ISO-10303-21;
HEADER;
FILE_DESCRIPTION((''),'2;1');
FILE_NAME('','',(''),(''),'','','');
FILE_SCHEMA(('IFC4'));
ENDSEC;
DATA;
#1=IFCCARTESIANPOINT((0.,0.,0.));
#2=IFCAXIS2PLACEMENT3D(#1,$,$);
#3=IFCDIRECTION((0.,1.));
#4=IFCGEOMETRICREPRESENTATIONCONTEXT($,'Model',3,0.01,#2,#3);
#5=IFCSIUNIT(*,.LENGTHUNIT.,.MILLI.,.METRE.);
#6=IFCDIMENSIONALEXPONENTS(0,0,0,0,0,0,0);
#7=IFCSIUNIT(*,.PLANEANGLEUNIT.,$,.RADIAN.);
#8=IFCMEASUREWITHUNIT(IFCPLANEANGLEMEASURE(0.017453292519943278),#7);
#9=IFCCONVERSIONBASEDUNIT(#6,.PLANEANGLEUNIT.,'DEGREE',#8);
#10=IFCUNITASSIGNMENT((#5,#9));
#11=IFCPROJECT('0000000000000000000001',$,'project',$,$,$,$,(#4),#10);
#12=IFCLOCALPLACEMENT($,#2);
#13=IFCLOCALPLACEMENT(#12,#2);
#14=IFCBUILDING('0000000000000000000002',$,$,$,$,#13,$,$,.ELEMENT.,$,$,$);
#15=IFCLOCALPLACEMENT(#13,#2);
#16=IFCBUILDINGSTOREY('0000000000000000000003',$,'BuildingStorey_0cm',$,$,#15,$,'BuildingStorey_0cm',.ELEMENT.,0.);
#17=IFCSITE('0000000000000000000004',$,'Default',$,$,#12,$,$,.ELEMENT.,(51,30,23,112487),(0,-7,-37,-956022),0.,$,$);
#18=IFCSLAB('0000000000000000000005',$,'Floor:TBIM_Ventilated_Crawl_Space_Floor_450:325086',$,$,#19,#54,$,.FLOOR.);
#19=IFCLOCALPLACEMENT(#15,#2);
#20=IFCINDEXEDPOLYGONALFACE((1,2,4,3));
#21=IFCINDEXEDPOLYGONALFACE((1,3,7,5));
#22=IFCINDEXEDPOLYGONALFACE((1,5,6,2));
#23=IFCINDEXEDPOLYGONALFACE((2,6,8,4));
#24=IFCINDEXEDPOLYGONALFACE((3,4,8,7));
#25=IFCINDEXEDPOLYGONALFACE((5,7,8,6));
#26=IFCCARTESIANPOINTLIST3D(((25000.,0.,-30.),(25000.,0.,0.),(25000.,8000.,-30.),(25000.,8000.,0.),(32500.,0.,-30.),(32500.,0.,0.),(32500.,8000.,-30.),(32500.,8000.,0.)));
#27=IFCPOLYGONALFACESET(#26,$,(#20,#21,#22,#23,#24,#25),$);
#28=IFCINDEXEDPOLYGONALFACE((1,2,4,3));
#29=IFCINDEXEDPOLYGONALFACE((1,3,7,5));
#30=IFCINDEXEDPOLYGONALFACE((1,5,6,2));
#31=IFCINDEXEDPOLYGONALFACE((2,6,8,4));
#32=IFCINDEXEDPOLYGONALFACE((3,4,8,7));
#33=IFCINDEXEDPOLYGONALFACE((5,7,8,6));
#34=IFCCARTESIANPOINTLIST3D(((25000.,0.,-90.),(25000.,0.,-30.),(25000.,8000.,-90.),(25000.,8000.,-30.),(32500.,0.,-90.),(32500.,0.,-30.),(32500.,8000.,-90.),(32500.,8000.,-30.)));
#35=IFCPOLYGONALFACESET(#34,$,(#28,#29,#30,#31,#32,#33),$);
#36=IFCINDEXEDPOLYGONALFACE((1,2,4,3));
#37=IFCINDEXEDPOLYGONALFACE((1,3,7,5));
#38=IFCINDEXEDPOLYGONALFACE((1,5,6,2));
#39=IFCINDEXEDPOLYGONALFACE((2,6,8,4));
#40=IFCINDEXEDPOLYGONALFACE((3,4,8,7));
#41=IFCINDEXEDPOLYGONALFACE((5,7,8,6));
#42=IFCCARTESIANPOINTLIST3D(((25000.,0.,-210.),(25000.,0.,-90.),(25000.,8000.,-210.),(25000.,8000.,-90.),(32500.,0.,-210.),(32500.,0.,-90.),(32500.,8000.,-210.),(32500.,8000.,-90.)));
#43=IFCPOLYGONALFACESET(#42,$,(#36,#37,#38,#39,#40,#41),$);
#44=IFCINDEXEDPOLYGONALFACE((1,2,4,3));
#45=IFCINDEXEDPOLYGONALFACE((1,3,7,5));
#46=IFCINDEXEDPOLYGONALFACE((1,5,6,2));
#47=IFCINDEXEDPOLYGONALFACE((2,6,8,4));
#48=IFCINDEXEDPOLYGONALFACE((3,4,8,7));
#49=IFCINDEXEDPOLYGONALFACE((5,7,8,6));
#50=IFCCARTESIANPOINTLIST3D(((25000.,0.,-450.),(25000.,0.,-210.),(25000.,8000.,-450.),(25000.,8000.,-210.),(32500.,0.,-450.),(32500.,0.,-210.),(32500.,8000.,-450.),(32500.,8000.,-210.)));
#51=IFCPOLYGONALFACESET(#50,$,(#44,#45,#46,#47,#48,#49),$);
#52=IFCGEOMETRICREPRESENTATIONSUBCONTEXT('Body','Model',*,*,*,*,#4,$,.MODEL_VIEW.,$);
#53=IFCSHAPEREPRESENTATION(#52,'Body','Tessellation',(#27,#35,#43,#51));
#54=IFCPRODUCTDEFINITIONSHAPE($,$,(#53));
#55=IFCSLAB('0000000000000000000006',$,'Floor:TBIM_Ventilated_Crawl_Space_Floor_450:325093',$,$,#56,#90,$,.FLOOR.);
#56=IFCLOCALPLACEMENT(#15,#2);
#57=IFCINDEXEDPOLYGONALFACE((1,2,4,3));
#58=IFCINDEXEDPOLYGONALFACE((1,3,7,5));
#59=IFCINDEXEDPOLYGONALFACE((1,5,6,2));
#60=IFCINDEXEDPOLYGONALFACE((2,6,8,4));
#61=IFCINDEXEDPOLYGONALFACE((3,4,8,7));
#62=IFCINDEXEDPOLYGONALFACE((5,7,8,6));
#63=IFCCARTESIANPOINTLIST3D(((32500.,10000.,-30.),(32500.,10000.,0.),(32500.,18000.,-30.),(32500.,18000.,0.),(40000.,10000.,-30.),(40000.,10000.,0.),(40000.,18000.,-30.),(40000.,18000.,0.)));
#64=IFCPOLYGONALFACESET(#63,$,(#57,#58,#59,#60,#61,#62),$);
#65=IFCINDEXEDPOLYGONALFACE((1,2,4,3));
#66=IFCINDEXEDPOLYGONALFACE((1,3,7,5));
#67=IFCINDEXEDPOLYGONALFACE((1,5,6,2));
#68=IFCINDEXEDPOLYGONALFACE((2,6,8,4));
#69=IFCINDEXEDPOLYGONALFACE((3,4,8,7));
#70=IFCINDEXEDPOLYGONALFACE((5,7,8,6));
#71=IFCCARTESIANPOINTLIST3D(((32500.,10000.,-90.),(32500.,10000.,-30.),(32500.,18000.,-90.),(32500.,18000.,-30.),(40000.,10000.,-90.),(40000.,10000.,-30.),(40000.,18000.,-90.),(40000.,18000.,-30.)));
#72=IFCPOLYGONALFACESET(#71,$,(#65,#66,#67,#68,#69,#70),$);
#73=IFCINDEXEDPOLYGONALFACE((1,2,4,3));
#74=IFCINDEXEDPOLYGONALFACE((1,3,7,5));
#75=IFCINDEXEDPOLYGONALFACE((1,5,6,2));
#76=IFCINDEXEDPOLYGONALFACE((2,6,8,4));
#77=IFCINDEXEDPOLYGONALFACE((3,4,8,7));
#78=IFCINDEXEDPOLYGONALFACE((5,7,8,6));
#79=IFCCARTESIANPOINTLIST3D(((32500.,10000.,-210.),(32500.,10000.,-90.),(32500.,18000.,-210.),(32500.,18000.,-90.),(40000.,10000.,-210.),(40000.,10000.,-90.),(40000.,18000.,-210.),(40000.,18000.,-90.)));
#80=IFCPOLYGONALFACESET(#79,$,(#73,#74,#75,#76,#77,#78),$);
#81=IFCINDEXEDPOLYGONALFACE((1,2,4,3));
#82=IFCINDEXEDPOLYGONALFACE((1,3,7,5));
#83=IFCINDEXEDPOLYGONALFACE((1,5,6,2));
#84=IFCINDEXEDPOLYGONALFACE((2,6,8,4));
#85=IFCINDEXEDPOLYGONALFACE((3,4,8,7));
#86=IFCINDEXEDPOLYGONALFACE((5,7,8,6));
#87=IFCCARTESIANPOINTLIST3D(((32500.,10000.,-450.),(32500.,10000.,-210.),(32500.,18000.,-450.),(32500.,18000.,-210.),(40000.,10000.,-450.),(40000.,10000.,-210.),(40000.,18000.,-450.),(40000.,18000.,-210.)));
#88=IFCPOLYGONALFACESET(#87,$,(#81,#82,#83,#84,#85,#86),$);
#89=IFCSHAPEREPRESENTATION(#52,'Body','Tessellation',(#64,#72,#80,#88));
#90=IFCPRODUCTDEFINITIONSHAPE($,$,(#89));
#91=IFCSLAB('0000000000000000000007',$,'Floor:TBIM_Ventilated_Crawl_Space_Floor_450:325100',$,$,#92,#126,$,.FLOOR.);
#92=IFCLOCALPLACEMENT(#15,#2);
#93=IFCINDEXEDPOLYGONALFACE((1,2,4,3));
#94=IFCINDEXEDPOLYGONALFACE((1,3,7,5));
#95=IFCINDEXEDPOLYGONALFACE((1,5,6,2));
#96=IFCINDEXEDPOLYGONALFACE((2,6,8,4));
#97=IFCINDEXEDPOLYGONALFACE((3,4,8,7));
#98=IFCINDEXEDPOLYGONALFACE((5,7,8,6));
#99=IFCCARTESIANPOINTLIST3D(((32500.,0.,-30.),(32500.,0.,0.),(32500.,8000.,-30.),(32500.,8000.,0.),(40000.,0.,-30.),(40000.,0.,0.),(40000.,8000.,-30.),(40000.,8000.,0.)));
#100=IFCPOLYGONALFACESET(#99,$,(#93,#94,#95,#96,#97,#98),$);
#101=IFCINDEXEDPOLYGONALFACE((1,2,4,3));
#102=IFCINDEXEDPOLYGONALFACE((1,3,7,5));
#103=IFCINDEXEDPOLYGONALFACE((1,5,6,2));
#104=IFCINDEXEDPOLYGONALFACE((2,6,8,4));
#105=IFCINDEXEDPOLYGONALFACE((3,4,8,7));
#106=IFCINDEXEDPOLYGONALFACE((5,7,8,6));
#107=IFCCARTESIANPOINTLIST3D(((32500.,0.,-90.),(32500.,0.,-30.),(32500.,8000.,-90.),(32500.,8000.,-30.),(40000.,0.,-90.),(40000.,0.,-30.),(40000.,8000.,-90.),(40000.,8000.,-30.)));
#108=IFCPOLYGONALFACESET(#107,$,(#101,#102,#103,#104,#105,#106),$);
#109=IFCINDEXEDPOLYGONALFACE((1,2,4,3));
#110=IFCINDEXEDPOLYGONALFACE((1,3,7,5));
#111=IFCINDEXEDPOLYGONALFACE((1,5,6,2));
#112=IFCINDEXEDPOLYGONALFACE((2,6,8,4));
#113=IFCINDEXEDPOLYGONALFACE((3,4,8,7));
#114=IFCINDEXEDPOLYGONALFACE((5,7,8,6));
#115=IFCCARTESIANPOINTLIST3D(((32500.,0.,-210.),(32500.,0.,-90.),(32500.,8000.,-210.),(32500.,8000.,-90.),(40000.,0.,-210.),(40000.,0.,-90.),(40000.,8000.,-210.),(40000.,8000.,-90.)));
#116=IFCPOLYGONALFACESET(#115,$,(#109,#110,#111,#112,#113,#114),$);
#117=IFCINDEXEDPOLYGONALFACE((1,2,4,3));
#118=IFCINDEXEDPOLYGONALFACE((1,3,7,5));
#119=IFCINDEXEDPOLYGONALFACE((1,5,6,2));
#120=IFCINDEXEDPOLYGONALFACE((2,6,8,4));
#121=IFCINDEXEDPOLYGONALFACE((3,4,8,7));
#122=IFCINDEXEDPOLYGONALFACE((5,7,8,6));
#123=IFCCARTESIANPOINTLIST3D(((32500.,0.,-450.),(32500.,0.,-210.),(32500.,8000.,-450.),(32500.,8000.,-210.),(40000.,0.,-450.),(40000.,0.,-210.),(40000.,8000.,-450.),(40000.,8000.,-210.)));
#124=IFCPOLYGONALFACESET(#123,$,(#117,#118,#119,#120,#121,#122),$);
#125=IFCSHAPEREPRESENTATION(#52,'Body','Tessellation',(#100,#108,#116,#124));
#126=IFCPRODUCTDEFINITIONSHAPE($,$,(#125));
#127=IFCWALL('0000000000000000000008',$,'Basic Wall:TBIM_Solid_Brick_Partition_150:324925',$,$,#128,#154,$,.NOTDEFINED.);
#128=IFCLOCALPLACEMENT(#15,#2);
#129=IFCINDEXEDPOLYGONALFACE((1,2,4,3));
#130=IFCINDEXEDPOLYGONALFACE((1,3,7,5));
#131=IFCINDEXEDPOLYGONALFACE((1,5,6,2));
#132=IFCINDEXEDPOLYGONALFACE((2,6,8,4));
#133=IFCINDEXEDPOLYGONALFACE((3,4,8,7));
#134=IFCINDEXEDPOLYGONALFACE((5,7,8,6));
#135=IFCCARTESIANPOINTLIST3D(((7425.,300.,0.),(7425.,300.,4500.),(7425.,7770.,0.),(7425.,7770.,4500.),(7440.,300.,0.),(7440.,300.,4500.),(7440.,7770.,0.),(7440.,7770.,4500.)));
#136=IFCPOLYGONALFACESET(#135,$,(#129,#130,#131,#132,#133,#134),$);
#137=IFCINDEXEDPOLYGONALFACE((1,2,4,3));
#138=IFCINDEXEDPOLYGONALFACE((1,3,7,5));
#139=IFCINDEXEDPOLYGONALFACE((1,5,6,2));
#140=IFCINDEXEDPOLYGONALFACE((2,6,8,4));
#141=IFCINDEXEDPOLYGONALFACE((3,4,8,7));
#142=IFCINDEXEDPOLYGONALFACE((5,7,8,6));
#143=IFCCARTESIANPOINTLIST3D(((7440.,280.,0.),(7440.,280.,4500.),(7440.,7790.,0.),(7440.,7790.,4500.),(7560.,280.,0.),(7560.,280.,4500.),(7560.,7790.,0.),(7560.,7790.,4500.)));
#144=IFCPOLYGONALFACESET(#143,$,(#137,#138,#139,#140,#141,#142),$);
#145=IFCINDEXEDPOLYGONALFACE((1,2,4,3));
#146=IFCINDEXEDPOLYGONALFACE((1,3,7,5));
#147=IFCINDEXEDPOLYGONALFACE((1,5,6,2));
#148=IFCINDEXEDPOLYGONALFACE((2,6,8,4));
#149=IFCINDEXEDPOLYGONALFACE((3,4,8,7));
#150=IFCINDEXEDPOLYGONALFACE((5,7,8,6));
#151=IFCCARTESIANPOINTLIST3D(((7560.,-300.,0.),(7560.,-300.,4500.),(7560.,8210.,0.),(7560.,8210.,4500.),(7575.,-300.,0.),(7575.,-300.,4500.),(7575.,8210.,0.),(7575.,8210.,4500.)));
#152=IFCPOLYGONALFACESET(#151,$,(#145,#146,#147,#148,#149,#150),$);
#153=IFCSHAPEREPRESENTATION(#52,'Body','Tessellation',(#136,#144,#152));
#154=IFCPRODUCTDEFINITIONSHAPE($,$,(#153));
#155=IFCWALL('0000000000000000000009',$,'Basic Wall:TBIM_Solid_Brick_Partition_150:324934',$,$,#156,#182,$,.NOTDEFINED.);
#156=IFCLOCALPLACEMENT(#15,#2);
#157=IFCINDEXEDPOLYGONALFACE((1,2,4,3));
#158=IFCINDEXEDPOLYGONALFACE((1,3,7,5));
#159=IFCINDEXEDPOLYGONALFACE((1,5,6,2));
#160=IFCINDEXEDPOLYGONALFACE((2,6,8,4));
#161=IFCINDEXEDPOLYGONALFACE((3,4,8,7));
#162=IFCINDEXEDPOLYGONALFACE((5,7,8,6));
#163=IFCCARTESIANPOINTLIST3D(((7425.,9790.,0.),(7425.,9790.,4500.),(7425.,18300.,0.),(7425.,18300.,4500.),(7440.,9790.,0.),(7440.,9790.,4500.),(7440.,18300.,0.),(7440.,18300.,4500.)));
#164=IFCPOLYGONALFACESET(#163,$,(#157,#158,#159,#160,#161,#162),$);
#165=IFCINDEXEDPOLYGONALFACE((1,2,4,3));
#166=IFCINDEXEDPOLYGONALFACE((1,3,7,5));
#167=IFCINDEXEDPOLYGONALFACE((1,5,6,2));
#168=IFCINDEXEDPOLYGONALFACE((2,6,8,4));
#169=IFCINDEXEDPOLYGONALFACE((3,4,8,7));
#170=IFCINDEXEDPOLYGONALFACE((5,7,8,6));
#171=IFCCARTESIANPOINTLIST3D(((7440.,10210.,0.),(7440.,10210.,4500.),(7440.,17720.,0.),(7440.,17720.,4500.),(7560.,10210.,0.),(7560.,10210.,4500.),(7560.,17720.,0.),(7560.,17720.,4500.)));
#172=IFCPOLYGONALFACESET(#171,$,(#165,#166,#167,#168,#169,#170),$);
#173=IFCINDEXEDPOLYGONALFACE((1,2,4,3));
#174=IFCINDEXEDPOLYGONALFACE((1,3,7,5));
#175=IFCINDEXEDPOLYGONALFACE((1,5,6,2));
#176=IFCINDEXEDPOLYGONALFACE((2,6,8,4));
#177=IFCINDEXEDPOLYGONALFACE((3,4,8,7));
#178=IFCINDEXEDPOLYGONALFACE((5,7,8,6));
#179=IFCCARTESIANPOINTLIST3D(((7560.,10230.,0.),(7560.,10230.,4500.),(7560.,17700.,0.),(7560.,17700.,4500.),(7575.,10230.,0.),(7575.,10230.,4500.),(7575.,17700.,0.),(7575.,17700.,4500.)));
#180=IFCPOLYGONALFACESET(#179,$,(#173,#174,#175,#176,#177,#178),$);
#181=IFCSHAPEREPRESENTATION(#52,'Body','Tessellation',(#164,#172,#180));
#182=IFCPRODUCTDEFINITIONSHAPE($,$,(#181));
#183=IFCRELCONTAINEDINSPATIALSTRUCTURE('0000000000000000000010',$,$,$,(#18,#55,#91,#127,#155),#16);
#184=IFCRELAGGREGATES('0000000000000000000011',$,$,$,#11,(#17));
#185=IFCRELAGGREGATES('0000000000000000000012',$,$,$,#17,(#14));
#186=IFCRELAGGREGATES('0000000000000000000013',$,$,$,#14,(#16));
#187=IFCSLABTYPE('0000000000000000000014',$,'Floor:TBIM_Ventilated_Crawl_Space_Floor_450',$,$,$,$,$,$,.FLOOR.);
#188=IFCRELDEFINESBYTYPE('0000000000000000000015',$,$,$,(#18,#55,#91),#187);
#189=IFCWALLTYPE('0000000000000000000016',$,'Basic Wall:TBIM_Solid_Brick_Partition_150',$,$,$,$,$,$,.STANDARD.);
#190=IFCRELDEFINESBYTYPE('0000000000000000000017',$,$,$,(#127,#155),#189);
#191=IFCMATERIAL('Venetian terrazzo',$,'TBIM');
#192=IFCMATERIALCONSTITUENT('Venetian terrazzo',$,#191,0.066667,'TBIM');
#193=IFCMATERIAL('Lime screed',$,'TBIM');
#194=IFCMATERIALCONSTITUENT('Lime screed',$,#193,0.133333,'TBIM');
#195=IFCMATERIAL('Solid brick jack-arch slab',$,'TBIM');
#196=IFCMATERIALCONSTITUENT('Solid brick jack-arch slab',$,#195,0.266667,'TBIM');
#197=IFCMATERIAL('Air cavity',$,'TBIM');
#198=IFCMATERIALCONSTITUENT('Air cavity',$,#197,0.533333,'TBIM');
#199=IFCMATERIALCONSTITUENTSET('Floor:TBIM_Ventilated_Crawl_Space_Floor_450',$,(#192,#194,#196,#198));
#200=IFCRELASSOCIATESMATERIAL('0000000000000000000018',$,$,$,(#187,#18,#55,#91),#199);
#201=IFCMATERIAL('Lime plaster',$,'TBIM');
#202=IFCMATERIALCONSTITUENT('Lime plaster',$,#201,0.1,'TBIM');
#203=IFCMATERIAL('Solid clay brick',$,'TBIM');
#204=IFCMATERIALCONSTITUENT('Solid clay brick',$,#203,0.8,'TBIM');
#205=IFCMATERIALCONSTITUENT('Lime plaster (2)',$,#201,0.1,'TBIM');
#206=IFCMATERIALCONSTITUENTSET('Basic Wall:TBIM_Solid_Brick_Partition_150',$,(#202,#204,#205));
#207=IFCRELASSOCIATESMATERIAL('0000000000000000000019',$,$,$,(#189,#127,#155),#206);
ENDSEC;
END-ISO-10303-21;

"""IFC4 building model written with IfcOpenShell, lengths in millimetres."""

from ifc_helpers import new_model, entity, si_unit, converted_unit, direction, frame, origin, place, context, subcontext, project, spatial, indexed_curve, outline, extrude, material, constituent, constituent_set, type_object, element, save


model = new_model("IFC4")

# Units and contexts
model_context = context("Model", 3, precision=0.01, world=origin(), true_north=direction((0.0, 1.0)))
body_context = subcontext(model_context, "Body", "Model", "MODEL_VIEW")
ifc_project = project(units=[si_unit("LENGTHUNIT", "METRE", prefix="MILLI"), converted_unit("PLANEANGLEUNIT", "DEGREE", entity("IfcPlaneAngleMeasure", 0.017453292519943278), si_unit("PLANEANGLEUNIT", "RADIAN"), dimensions=[0, 0, 0, 0, 0, 0, 0])], contexts=[model_context])

# Site, building, storey
site_placement = place(None, origin())
site = spatial("IfcSite", under=ifc_project, at=site_placement, Name="Default", CompositionType="ELEMENT", RefLatitude=(51, 30, 23, 112487), RefLongitude=(0, -7, -37, -956022), RefElevation=0.0)
building_placement = place(site_placement, origin())
building = spatial("IfcBuilding", under=site, at=building_placement, CompositionType="ELEMENT")
storey_placement = place(building_placement, origin())
storey = spatial("IfcBuildingStorey", under=building, at=storey_placement, Name="BuildingStorey_0cm", LongName="BuildingStorey_0cm", CompositionType="ELEMENT", Elevation=0.0)

# Slabs
ifc_material_1 = material(Name="Venetian terrazzo", Category="TBIM")
ifc_constituent_1 = constituent(ifc_material_1, Name="Venetian terrazzo", Category="TBIM", fraction=0.066667)
ifc_material_2 = material(Name="Lime screed", Category="TBIM")
ifc_constituent_2 = constituent(ifc_material_2, Name="Lime screed", Category="TBIM", fraction=0.133333)
ifc_material_3 = material(Name="Solid brick jack-arch slab", Category="TBIM")
ifc_constituent_3 = constituent(ifc_material_3, Name="Solid brick jack-arch slab", Category="TBIM", fraction=0.266667)
ifc_material_4 = material(Name="Air cavity", Category="TBIM")
ifc_constituent_4 = constituent(ifc_material_4, Name="Air cavity", Category="TBIM", fraction=0.533333)
ifc_constituent_set_1 = constituent_set(constituents=[ifc_constituent_1, ifc_constituent_2, ifc_constituent_3, ifc_constituent_4], Name="Floor:TBIM_Ventilated_Crawl_Space_Floor_450")
slab_type = type_object("IfcSlabType", Name="Floor:TBIM_Ventilated_Crawl_Space_Floor_450", PredefinedType="FLOOR", material=ifc_constituent_set_1)
slab_1_placement = place(storey_placement, origin())
element("IfcSlab", 1, at=slab_1_placement, inside=storey, type_object=slab_type, material=ifc_constituent_set_1, Name="Floor:TBIM_Ventilated_Crawl_Space_Floor_450:325086", PredefinedType="FLOOR", context=body_context, shape_type="SweptSolid", body=[
    extrude(outline(indexed_curve([(-3750.0, -4000.0), (3750.0, -4000.0), (3750.0, 4000.0), (-3750.0, 4000.0), (-3750.0, -4000.0)], self_intersect=False)), frame((28750.0, 4000.0, -30.0), z_axis=(0.0, 0.0, 1.0), x_axis=(-1.0, 0.0, 0.0)), (0.0, 0.0, 1.0), 30.0),
    extrude(outline(indexed_curve([(-3750.0, -4000.0), (3750.0, -4000.0), (3750.0, 4000.0), (-3750.0, 4000.0), (-3750.0, -4000.0)], self_intersect=False)), frame((28750.0, 4000.0, -90.0), z_axis=(0.0, 0.0, 1.0), x_axis=(-1.0, 0.0, 0.0)), (0.0, 0.0, 1.0), 60.0),
    extrude(outline(indexed_curve([(-3750.0, -4000.0), (3750.0, -4000.0), (3750.0, 4000.0), (-3750.0, 4000.0), (-3750.0, -4000.0)], self_intersect=False)), frame((28750.0, 4000.0, -210.0), z_axis=(0.0, 0.0, 1.0), x_axis=(-1.0, 0.0, 0.0)), (0.0, 0.0, 1.0), 120.0),
    extrude(outline(indexed_curve([(-3750.0, -4000.0), (3750.0, -4000.0), (3750.0, 4000.0), (-3750.0, 4000.0), (-3750.0, -4000.0)], self_intersect=False)), frame((28750.0, 4000.0, -450.0), z_axis=(0.0, 0.0, 1.0), x_axis=(-1.0, 0.0, 0.0)), (0.0, 0.0, 1.0), 240.0),
])
slab_2_placement = place(storey_placement, origin())
element("IfcSlab", 2, at=slab_2_placement, inside=storey, type_object=slab_type, material=ifc_constituent_set_1, Name="Floor:TBIM_Ventilated_Crawl_Space_Floor_450:325093", PredefinedType="FLOOR", context=body_context, shape_type="SweptSolid", body=[
    extrude(outline(indexed_curve([(-3750.0, -4000.0), (3750.0, -4000.0), (3750.0, 4000.0), (-3750.0, 4000.0), (-3750.0, -4000.0)], self_intersect=False)), frame((36250.0, 14000.0, -30.0), z_axis=(0.0, 0.0, 1.0), x_axis=(-1.0, 0.0, 0.0)), (0.0, 0.0, 1.0), 30.0),
    extrude(outline(indexed_curve([(-3750.0, -4000.0), (3750.0, -4000.0), (3750.0, 4000.0), (-3750.0, 4000.0), (-3750.0, -4000.0)], self_intersect=False)), frame((36250.0, 14000.0, -90.0), z_axis=(0.0, 0.0, 1.0), x_axis=(-1.0, 0.0, 0.0)), (0.0, 0.0, 1.0), 60.0),
    extrude(outline(indexed_curve([(-3750.0, -4000.0), (3750.0, -4000.0), (3750.0, 4000.0), (-3750.0, 4000.0), (-3750.0, -4000.0)], self_intersect=False)), frame((36250.0, 14000.0, -210.0), z_axis=(0.0, 0.0, 1.0), x_axis=(-1.0, 0.0, 0.0)), (0.0, 0.0, 1.0), 120.0),
    extrude(outline(indexed_curve([(-3750.0, -4000.0), (3750.0, -4000.0), (3750.0, 4000.0), (-3750.0, 4000.0), (-3750.0, -4000.0)], self_intersect=False)), frame((36250.0, 14000.0, -450.0), z_axis=(0.0, 0.0, 1.0), x_axis=(-1.0, 0.0, 0.0)), (0.0, 0.0, 1.0), 240.0),
])
slab_3_placement = place(storey_placement, origin())
element("IfcSlab", 3, at=slab_3_placement, inside=storey, type_object=slab_type, material=ifc_constituent_set_1, Name="Floor:TBIM_Ventilated_Crawl_Space_Floor_450:325100", PredefinedType="FLOOR", context=body_context, shape_type="SweptSolid", body=[
    extrude(outline(indexed_curve([(-3750.0, -4000.0), (3750.0, -4000.0), (3750.0, 4000.0), (-3750.0, 4000.0), (-3750.0, -4000.0)], self_intersect=False)), frame((36250.0, 4000.0, -30.0), z_axis=(0.0, 0.0, 1.0), x_axis=(-1.0, 0.0, 0.0)), (0.0, 0.0, 1.0), 30.0),
    extrude(outline(indexed_curve([(-3750.0, -4000.0), (3750.0, -4000.0), (3750.0, 4000.0), (-3750.0, 4000.0), (-3750.0, -4000.0)], self_intersect=False)), frame((36250.0, 4000.0, -90.0), z_axis=(0.0, 0.0, 1.0), x_axis=(-1.0, 0.0, 0.0)), (0.0, 0.0, 1.0), 60.0),
    extrude(outline(indexed_curve([(-3750.0, -4000.0), (3750.0, -4000.0), (3750.0, 4000.0), (-3750.0, 4000.0), (-3750.0, -4000.0)], self_intersect=False)), frame((36250.0, 4000.0, -210.0), z_axis=(0.0, 0.0, 1.0), x_axis=(-1.0, 0.0, 0.0)), (0.0, 0.0, 1.0), 120.0),
    extrude(outline(indexed_curve([(-3750.0, -4000.0), (3750.0, -4000.0), (3750.0, 4000.0), (-3750.0, 4000.0), (-3750.0, -4000.0)], self_intersect=False)), frame((36250.0, 4000.0, -450.0), z_axis=(0.0, 0.0, 1.0), x_axis=(-1.0, 0.0, 0.0)), (0.0, 0.0, 1.0), 240.0),
])

# Shared definitions
ifc_material_5 = material(Name="Solid clay brick", Category="TBIM")
ifc_material_6 = material(Name="Lime plaster", Category="TBIM")

# Walls
ifc_constituent_5 = constituent(ifc_material_6, Name="Lime plaster", Category="TBIM", fraction=0.1)
ifc_constituent_6 = constituent(ifc_material_5, Name="Solid clay brick", Category="TBIM", fraction=0.8)
ifc_constituent_7 = constituent(ifc_material_6, Name="Lime plaster (2)", Category="TBIM", fraction=0.1)
ifc_constituent_set_2 = constituent_set(constituents=[ifc_constituent_5, ifc_constituent_6, ifc_constituent_7], Name="Basic Wall:TBIM_Solid_Brick_Partition_150")
wall_type_1 = type_object("IfcWallType", Name="Basic Wall:TBIM_Solid_Brick_Partition_150", PredefinedType="STANDARD", material=ifc_constituent_set_2)
wall_1_placement = place(storey_placement, frame((7500.0, 300.0, 0.0), z_axis=(0.0, 0.0, 1.0), x_axis=(0.0, 1.0, 0.0)))
element("IfcWall", 4, at=wall_1_placement, inside=storey, type_object=wall_type_1, material=ifc_constituent_set_2, Name="Basic Wall:TBIM_Solid_Brick_Partition_150:324925", PredefinedType="NOTDEFINED", context=body_context, shape_type="SweptSolid", body=[
    extrude(outline(indexed_curve([(-7.5, -3735.0), (7.5, -3735.0), (7.5, 3735.0), (-7.5, 3735.0), (-7.5, -3735.0)], self_intersect=False)), frame((3735.0, 67.5, 0.0), z_axis=(0.0, 0.0, 1.0), x_axis=(0.0, -1.0, 0.0)), (0.0, 0.0, 1.0), 4500.0),
    extrude(outline(indexed_curve([(-3755.0, -60.0), (3755.0, -60.0), (3755.0, 60.0), (-3755.0, 60.0), (-3755.0, -60.0)], self_intersect=False)), frame((3735.0, 0.0, 0.0)), (0.0, 0.0, 1.0), 4500.0),
    extrude(outline(indexed_curve([(-7.5, -4255.0), (7.5, -4255.0), (7.5, 4255.0), (-7.5, 4255.0), (-7.5, -4255.0)], self_intersect=False)), frame((3655.0, -67.5, 0.0), z_axis=(0.0, 0.0, 1.0), x_axis=(0.0, 1.0, 0.0)), (0.0, 0.0, 1.0), 4500.0),
])
wall_2_placement = place(storey_placement, frame((7500.0, 10230.0, 0.0), z_axis=(0.0, 0.0, 1.0), x_axis=(0.0, 1.0, 0.0)))
element("IfcWall", 5, at=wall_2_placement, inside=storey, type_object=wall_type_1, material=ifc_constituent_set_2, Name="Basic Wall:TBIM_Solid_Brick_Partition_150:324934", PredefinedType="NOTDEFINED", context=body_context, shape_type="SweptSolid", body=[
    extrude(outline(indexed_curve([(-7.5, -4255.0), (7.5, -4255.0), (7.5, 4255.0), (-7.5, 4255.0), (-7.5, -4255.0)], self_intersect=False)), frame((3815.0, 67.5, 0.0), z_axis=(0.0, 0.0, 1.0), x_axis=(0.0, -1.0, 0.0)), (0.0, 0.0, 1.0), 4500.0),
    extrude(outline(indexed_curve([(-3755.0, -60.0), (3755.0, -60.0), (3755.0, 60.0), (-3755.0, 60.0), (-3755.0, -60.0)], self_intersect=False)), frame((3735.0, 0.0, 0.0)), (0.0, 0.0, 1.0), 4500.0),
    extrude(outline(indexed_curve([(-7.5, -3735.0), (7.5, -3735.0), (7.5, 3735.0), (-7.5, 3735.0), (-7.5, -3735.0)], self_intersect=False)), frame((3735.0, -67.5, 0.0), z_axis=(0.0, 0.0, 1.0), x_axis=(0.0, 1.0, 0.0)), (0.0, 0.0, 1.0), 4500.0),
])

save(model, "model.ifc")
